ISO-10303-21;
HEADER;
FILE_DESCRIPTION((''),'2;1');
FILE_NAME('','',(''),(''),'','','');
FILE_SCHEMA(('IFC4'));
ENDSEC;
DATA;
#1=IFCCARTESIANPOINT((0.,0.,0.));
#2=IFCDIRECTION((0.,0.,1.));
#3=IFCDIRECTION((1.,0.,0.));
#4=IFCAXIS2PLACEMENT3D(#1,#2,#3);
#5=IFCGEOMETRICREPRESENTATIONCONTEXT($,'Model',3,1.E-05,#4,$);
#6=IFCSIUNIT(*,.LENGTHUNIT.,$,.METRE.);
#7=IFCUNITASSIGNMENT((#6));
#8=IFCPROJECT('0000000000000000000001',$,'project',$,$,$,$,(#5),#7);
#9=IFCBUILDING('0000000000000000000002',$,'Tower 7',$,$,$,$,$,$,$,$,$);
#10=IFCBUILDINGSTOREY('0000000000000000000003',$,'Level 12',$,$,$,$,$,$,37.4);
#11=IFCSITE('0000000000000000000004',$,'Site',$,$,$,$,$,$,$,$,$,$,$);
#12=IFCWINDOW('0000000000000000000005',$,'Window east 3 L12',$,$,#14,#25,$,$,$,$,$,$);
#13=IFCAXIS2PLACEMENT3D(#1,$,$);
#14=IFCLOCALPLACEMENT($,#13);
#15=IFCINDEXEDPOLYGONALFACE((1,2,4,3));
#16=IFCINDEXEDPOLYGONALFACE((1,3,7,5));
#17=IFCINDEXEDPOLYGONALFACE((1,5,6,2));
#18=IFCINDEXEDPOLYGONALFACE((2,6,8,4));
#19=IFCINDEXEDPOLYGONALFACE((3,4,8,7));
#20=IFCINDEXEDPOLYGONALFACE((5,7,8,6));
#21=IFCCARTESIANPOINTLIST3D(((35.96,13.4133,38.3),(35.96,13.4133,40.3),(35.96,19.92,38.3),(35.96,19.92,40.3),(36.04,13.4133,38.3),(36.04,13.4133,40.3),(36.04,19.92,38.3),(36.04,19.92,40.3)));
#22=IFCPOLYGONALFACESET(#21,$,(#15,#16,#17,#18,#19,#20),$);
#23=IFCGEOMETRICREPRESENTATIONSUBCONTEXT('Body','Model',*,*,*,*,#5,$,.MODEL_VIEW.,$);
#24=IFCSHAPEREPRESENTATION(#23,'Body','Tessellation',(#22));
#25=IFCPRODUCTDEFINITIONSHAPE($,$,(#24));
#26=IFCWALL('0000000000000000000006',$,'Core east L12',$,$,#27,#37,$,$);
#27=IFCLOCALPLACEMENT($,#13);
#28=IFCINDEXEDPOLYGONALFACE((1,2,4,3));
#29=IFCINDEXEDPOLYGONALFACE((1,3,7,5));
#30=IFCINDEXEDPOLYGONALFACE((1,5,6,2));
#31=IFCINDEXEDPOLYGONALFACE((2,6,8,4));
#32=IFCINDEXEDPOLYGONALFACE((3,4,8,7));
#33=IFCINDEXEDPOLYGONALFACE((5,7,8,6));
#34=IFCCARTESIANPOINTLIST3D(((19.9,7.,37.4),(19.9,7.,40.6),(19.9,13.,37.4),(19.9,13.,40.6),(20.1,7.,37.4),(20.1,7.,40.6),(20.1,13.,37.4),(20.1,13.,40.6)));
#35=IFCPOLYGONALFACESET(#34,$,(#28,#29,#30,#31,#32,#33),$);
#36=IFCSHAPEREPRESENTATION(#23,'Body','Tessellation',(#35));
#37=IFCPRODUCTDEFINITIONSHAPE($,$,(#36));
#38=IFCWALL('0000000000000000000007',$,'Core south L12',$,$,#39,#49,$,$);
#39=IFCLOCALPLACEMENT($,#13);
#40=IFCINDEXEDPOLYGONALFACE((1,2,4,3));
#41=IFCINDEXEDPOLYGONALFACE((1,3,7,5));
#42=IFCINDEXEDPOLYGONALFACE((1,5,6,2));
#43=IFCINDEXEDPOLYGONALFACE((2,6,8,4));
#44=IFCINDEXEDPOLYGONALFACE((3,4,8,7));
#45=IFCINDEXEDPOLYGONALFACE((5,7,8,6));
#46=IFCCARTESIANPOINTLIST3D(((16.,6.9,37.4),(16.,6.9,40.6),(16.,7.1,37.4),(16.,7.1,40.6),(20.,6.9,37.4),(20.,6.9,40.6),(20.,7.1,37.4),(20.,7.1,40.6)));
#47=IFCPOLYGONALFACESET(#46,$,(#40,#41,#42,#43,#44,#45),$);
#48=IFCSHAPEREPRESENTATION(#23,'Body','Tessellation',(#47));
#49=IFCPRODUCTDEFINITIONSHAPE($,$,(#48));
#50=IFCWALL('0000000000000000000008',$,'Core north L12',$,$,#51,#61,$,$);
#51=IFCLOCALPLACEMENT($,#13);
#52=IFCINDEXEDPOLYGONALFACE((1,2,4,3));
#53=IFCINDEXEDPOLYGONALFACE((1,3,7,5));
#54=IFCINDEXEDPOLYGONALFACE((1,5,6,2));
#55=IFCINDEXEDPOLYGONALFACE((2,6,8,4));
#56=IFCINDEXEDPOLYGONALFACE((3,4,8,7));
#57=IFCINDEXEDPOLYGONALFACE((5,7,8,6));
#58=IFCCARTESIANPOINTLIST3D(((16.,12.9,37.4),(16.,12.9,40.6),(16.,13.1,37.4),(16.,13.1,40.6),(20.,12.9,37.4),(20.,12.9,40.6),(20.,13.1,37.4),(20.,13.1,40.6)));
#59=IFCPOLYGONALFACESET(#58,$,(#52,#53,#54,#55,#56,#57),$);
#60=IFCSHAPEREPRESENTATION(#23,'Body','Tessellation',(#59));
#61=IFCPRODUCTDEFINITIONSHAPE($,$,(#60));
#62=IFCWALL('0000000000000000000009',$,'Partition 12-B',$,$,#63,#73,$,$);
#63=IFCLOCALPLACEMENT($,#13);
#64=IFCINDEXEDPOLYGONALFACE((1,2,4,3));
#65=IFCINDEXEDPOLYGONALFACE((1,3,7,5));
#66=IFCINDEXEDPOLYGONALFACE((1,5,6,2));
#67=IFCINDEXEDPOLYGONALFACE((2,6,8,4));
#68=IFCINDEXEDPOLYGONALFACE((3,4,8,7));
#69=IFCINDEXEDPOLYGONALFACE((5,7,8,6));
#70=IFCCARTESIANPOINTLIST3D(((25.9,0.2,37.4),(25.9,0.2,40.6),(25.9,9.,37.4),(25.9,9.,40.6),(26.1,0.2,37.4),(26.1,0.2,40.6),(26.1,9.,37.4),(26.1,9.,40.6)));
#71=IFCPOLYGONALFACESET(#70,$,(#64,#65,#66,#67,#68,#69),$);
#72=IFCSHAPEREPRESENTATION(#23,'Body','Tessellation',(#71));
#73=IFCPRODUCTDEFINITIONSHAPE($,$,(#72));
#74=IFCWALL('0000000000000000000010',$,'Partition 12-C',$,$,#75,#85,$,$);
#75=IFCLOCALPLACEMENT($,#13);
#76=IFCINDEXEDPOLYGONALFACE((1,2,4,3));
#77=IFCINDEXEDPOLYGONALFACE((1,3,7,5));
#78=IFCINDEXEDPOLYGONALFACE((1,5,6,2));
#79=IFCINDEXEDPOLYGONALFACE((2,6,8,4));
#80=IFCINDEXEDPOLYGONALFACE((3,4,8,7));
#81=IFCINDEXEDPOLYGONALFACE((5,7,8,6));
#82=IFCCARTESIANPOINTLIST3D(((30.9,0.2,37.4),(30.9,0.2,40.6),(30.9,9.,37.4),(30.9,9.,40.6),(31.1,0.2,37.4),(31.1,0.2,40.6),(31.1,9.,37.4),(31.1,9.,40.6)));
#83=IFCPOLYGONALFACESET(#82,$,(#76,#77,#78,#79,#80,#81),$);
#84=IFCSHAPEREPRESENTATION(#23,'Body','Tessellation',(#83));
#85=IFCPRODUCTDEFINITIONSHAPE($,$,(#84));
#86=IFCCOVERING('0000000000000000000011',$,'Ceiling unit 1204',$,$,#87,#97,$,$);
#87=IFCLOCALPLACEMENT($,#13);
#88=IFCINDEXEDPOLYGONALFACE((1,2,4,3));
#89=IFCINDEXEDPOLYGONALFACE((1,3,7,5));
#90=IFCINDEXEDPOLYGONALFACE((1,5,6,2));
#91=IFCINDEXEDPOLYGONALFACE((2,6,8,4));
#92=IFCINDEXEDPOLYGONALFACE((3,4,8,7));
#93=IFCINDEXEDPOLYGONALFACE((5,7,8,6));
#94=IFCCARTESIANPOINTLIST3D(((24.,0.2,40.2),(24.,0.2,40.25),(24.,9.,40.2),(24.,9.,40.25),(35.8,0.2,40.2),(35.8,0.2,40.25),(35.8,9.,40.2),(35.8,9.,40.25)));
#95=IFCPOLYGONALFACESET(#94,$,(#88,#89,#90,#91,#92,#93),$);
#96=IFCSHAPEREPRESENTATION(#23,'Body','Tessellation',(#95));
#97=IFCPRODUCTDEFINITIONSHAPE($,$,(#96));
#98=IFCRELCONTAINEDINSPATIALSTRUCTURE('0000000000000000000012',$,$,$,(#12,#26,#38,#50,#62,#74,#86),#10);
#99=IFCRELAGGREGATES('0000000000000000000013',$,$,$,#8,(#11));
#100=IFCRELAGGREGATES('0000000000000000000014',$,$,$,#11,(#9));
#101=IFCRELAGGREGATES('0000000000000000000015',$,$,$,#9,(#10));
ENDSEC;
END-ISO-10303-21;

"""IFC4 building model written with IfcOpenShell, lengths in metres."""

from ifc_helpers import new_model, si_unit, frame, origin, origin_with_axes, origin_2d, place, context, subcontext, project, spatial, rectangle, extrude, element, save


model = new_model("IFC4")

# Units and contexts
model_context = context("Model", 3, precision=1e-05, world=origin_with_axes())
body_context = subcontext(model_context, "Body", "Model", "MODEL_VIEW")
ifc_project = project(units=[si_unit("LENGTHUNIT", "METRE")], contexts=[model_context])

# Site, building, storey
site = spatial("IfcSite", under=ifc_project, Name="Site")
building = spatial("IfcBuilding", under=site, Name="Tower 7")
storey = spatial("IfcBuildingStorey", under=building, Name="Level 12", Elevation=37.4)

# Window
window_placement = place(None, frame((36.0, 16.6667, 38.3), z_axis=(0.0, 0.0, 1.0), x_axis=(1.0, 0.0, 0.0)))
element("IfcWindow", 1, at=window_placement, inside=storey, Name="Window east 3 L12", context=body_context, shape_type="SweptSolid", body=[
    extrude(rectangle(XDim=0.08, YDim=6.5067, at=origin_2d()), origin(), (0.0, 0.0, 1.0), 2.0),
])

# Walls
wall_1_placement = place(None, frame((20.0, 10.0, 37.4), z_axis=(0.0, 0.0, 1.0), x_axis=(1.0, 0.0, 0.0)))
element("IfcWall", 2, at=wall_1_placement, inside=storey, Name="Core east L12", context=body_context, shape_type="SweptSolid", body=[
    extrude(rectangle(XDim=0.2, YDim=6.0, at=origin_2d()), origin(), (0.0, 0.0, 1.0), 3.2),
])
for number, where, z_axis, x_axis, name in (
    (3, (18.0, 7.0, 37.4), (0.0, 0.0, 1.0), (1.0, 0.0, 0.0), "Core south L12"),
    (4, (18.0, 13.0, 37.4), (0.0, 0.0, 1.0), (1.0, 0.0, 0.0), "Core north L12"),
):
    element("IfcWall", number, at=place(None, frame(where, z_axis=z_axis, x_axis=x_axis)), inside=storey, Name=name, context=body_context, shape_type="SweptSolid", body=[
        extrude(rectangle(XDim=4.0, YDim=0.2, at=origin_2d()), origin(), (0.0, 0.0, 1.0), 3.2),
    ])
for number, where, z_axis, x_axis, name in (
    (5, (26.0, 4.6, 37.4), (0.0, 0.0, 1.0), (1.0, 0.0, 0.0), "Partition 12-B"),
    (6, (31.0, 4.6, 37.4), (0.0, 0.0, 1.0), (1.0, 0.0, 0.0), "Partition 12-C"),
):
    element("IfcWall", number, at=place(None, frame(where, z_axis=z_axis, x_axis=x_axis)), inside=storey, Name=name, context=body_context, shape_type="SweptSolid", body=[
        extrude(rectangle(XDim=0.2, YDim=8.8, at=origin_2d()), origin(), (0.0, 0.0, 1.0), 3.2),
    ])

# Covering
covering_placement = place(None, frame((29.9, 4.6, 40.2), z_axis=(0.0, 0.0, 1.0), x_axis=(1.0, 0.0, 0.0)))
element("IfcCovering", 7, at=covering_placement, inside=storey, Name="Ceiling unit 1204", context=body_context, shape_type="SweptSolid", body=[
    extrude(rectangle(XDim=11.8, YDim=8.8, at=origin_2d()), origin(), (0.0, 0.0, 1.0), 0.05),
])

save(model, "model.ifc")
